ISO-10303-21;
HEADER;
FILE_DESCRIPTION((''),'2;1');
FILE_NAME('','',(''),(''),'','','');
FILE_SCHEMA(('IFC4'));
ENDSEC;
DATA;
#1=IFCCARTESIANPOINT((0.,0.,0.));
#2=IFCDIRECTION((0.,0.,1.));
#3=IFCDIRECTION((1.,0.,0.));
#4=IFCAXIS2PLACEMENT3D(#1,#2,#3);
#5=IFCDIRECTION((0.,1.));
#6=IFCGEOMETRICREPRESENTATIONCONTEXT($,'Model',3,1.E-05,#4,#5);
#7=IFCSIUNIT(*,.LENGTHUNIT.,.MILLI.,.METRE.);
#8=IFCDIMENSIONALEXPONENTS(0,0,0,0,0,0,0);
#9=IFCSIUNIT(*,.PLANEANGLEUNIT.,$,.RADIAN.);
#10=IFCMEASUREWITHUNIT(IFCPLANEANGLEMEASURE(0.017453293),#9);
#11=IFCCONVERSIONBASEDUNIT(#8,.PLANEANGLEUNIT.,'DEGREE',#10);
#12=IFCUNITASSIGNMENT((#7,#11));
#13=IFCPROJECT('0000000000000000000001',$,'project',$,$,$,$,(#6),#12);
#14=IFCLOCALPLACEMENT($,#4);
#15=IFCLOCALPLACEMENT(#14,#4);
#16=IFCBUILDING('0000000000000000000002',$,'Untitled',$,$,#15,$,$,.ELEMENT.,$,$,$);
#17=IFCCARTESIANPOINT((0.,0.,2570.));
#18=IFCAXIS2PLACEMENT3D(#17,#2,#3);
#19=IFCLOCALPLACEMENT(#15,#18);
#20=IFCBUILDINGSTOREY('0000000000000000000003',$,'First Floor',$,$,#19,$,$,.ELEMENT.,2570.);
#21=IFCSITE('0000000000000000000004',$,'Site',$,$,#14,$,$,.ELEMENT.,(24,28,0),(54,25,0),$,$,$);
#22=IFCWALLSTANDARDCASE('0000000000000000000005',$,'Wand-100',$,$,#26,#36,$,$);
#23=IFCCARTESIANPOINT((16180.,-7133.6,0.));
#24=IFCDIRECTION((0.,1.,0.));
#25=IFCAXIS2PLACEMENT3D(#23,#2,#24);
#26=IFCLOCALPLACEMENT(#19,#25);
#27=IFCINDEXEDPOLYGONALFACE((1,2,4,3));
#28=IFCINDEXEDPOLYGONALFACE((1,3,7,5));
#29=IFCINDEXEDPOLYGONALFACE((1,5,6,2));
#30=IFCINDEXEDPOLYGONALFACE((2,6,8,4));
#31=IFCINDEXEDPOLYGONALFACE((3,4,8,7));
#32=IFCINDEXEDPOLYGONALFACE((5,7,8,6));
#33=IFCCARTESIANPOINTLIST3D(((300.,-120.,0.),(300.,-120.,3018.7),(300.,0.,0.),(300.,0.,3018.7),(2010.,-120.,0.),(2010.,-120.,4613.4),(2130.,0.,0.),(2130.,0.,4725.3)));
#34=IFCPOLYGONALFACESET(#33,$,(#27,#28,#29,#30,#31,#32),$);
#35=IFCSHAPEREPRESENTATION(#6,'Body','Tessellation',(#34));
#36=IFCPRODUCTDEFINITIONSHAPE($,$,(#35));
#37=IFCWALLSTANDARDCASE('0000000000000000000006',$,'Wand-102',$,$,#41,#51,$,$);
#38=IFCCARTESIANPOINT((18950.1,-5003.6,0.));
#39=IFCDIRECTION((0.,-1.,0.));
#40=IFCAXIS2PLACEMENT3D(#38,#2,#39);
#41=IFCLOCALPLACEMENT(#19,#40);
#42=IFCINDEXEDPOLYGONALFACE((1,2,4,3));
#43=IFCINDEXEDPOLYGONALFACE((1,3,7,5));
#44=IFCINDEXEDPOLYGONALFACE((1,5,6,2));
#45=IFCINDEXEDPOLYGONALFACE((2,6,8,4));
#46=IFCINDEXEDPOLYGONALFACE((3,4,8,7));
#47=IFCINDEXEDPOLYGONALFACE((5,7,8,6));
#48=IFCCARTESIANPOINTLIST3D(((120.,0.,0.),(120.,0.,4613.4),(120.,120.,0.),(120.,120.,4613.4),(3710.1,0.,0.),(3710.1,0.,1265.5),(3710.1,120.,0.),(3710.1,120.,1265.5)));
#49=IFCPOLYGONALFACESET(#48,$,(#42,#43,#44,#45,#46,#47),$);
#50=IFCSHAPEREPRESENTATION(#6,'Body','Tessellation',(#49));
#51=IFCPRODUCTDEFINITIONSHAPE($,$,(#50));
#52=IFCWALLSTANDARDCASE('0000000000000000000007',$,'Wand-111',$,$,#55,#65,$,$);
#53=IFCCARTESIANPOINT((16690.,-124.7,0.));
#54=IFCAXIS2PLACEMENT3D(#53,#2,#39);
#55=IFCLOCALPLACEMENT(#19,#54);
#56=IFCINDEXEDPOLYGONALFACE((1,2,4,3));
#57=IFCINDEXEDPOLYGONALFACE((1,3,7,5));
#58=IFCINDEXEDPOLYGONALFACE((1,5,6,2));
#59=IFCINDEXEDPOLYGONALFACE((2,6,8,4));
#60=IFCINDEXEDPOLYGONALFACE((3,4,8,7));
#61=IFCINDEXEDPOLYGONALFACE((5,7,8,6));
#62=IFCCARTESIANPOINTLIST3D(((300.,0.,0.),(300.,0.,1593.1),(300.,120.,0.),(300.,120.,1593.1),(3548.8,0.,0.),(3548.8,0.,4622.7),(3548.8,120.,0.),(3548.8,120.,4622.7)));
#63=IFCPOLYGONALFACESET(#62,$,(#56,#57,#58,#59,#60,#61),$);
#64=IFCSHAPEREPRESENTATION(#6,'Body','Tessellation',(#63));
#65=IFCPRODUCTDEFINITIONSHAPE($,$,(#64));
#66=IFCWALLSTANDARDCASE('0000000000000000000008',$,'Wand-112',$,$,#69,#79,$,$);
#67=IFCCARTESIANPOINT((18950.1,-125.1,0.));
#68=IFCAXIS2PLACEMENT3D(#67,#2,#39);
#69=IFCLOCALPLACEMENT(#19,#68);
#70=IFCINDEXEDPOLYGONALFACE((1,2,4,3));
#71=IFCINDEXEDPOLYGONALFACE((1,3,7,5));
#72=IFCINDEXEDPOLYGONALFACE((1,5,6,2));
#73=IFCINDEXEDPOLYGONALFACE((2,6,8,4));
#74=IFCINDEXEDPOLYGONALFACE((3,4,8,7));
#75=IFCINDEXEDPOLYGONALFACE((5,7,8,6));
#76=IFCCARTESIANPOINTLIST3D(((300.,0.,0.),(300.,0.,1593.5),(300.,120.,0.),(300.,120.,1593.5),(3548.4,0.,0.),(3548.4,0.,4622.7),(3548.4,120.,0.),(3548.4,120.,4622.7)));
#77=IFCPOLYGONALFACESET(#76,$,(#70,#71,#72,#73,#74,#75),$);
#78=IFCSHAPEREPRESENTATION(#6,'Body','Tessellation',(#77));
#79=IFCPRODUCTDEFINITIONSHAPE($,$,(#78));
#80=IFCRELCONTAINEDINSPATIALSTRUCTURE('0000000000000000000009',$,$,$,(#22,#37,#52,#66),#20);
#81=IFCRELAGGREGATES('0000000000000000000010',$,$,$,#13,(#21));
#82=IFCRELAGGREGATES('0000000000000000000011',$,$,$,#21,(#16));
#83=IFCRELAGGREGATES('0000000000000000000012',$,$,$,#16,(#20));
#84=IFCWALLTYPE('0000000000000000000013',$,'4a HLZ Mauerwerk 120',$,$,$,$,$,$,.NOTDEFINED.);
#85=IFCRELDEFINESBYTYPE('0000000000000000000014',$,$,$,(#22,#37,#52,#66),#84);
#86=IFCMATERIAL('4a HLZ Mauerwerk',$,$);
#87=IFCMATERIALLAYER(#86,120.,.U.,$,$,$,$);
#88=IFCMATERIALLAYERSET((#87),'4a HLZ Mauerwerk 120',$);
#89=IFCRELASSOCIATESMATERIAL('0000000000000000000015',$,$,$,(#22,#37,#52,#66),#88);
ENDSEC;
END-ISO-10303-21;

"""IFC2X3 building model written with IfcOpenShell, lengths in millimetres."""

from ifc_helpers import new_model, entity, si_unit, converted_unit, direction, frame, origin_with_axes, place, context, project, spatial, polyline, outline, extrude, clip, halfspace, material, layer, layer_set, layer_usage, type_object, element, save


model = new_model("IFC2X3")

# Units and contexts
model_context = context("Model", 3, precision=1e-05, world=origin_with_axes(), true_north=direction((0.0, 1.0)))
ifc_project = project(units=[si_unit("LENGTHUNIT", "METRE", prefix="MILLI"), converted_unit("PLANEANGLEUNIT", "DEGREE", entity("IfcPlaneAngleMeasure", 0.017453293), si_unit("PLANEANGLEUNIT", "RADIAN"), dimensions=[0, 0, 0, 0, 0, 0, 0])], contexts=[model_context])

# Site, building, storey
site_placement = place(None, origin_with_axes())
site = spatial("IfcSite", under=ifc_project, at=site_placement, Name="Site", CompositionType="ELEMENT", RefLatitude=(24, 28, 0), RefLongitude=(54, 25, 0))
building_placement = place(site_placement, origin_with_axes())
building = spatial("IfcBuilding", under=site, at=building_placement, Name="Untitled", CompositionType="ELEMENT")
storey_placement = place(building_placement, frame((0.0, 0.0, 2570.0), z_axis=(0.0, 0.0, 1.0), x_axis=(1.0, 0.0, 0.0)))
storey = spatial("IfcBuildingStorey", under=building, at=storey_placement, Name="First Floor", CompositionType="ELEMENT", Elevation=2570.0)

# Shared definitions
ifc_material_1 = material(Name="4a HLZ Mauerwerk")

# Wall
ifc_layer_1 = layer(ifc_material_1, 120.0, ventilated="UNKNOWN")
ifc_layer_set_1 = layer_set([ifc_layer_1], Name="4a HLZ Mauerwerk 120")
ifc_layer_usage_1 = layer_usage(ifc_layer_set_1, "AXIS2", "NEGATIVE", 0.0)
wall_type_1 = type_object("IfcWallType", Name="4a HLZ Mauerwerk 120", PredefinedType="NOTDEFINED")
wall_1_placement = place(storey_placement, frame((16180.0, -7133.6, 0.0), z_axis=(0.0, 0.0, 1.0), x_axis=(0.0, 1.0, 0.0)))
element("IfcWallStandardCase", 1, at=wall_1_placement, inside=storey, type_object=wall_type_1, material=ifc_layer_usage_1, Name="Wand-100", context=model_context, shape_type="Clipping", body=[
    clip(extrude(outline(polyline([(300.0, -120.0), (2010.0, -120.0), (2130.0, 0.0), (300.0, 0.0), (300.0, -120.0)])), origin_with_axes(), (0.0, 0.0, 1.0), 5316.0), halfspace(frame((-1366.1, 0.0, 1465.0), z_axis=(0.681998, 0.0, -0.731354), x_axis=(0.731354, 0.0, 0.681998)), True)),
])

# Walls
ifc_layer_usage_2 = layer_usage(ifc_layer_set_1, "AXIS2", "POSITIVE", 0.0)
wall_2_placement = place(storey_placement, frame((18950.1, -5003.6, 0.0), z_axis=(0.0, 0.0, 1.0), x_axis=(0.0, -1.0, 0.0)))
element("IfcWallStandardCase", 2, at=wall_2_placement, inside=storey, type_object=wall_type_1, material=ifc_layer_usage_2, Name="Wand-102", context=model_context, shape_type="Clipping", body=[
    clip(extrude(outline(polyline([(120.0, 0.0), (3710.1, 0.0), (3710.1, 120.0), (120.0, 120.0), (120.0, 0.0)])), origin_with_axes(), (0.0, 0.0, 1.0), 5316.0), halfspace(frame((2356.9, 0.0, 2527.4), z_axis=(-0.681998, 0.0, -0.731354), x_axis=(0.731354, 0.0, -0.681998)), True)),
])
ifc_layer_usage_3 = layer_usage(ifc_layer_set_1, "AXIS2", "POSITIVE", 0.0)
wall_3_placement = place(storey_placement, frame((16690.0, -124.7, 0.0), z_axis=(0.0, 0.0, 1.0), x_axis=(0.0, -1.0, 0.0)))
element("IfcWallStandardCase", 3, at=wall_3_placement, inside=storey, type_object=wall_type_1, material=ifc_layer_usage_3, Name="Wand-111", context=model_context, shape_type="Clipping", body=[
    clip(extrude(outline(polyline([(300.0, 0.0), (3548.8, 0.0), (3548.8, 120.0), (300.0, 120.0), (300.0, 0.0)])), origin_with_axes(), (0.0, 0.0, 1.0), 5316.0), halfspace(frame((-655.1, 0.0, 702.5), z_axis=(0.681998, 0.0, -0.731354), x_axis=(0.731354, 0.0, 0.681998)), True)),
])
ifc_layer_usage_4 = layer_usage(ifc_layer_set_1, "AXIS2", "POSITIVE", 0.0)
wall_4_placement = place(storey_placement, frame((18950.1, -125.1, 0.0), z_axis=(0.0, 0.0, 1.0), x_axis=(0.0, -1.0, 0.0)))
element("IfcWallStandardCase", 4, at=wall_4_placement, inside=storey, type_object=wall_type_1, material=ifc_layer_usage_4, Name="Wand-112", context=model_context, shape_type="Clipping", body=[
    clip(extrude(outline(polyline([(300.0, 0.0), (3548.4, 0.0), (3548.4, 120.0), (300.0, 120.0), (300.0, 0.0)])), origin_with_axes(), (0.0, 0.0, 1.0), 5316.0), halfspace(frame((-655.3, 0.0, 702.7), z_axis=(0.681998, 0.0, -0.731354), x_axis=(0.731354, 0.0, 0.681998)), True)),
])

save(model, "model.ifc")
